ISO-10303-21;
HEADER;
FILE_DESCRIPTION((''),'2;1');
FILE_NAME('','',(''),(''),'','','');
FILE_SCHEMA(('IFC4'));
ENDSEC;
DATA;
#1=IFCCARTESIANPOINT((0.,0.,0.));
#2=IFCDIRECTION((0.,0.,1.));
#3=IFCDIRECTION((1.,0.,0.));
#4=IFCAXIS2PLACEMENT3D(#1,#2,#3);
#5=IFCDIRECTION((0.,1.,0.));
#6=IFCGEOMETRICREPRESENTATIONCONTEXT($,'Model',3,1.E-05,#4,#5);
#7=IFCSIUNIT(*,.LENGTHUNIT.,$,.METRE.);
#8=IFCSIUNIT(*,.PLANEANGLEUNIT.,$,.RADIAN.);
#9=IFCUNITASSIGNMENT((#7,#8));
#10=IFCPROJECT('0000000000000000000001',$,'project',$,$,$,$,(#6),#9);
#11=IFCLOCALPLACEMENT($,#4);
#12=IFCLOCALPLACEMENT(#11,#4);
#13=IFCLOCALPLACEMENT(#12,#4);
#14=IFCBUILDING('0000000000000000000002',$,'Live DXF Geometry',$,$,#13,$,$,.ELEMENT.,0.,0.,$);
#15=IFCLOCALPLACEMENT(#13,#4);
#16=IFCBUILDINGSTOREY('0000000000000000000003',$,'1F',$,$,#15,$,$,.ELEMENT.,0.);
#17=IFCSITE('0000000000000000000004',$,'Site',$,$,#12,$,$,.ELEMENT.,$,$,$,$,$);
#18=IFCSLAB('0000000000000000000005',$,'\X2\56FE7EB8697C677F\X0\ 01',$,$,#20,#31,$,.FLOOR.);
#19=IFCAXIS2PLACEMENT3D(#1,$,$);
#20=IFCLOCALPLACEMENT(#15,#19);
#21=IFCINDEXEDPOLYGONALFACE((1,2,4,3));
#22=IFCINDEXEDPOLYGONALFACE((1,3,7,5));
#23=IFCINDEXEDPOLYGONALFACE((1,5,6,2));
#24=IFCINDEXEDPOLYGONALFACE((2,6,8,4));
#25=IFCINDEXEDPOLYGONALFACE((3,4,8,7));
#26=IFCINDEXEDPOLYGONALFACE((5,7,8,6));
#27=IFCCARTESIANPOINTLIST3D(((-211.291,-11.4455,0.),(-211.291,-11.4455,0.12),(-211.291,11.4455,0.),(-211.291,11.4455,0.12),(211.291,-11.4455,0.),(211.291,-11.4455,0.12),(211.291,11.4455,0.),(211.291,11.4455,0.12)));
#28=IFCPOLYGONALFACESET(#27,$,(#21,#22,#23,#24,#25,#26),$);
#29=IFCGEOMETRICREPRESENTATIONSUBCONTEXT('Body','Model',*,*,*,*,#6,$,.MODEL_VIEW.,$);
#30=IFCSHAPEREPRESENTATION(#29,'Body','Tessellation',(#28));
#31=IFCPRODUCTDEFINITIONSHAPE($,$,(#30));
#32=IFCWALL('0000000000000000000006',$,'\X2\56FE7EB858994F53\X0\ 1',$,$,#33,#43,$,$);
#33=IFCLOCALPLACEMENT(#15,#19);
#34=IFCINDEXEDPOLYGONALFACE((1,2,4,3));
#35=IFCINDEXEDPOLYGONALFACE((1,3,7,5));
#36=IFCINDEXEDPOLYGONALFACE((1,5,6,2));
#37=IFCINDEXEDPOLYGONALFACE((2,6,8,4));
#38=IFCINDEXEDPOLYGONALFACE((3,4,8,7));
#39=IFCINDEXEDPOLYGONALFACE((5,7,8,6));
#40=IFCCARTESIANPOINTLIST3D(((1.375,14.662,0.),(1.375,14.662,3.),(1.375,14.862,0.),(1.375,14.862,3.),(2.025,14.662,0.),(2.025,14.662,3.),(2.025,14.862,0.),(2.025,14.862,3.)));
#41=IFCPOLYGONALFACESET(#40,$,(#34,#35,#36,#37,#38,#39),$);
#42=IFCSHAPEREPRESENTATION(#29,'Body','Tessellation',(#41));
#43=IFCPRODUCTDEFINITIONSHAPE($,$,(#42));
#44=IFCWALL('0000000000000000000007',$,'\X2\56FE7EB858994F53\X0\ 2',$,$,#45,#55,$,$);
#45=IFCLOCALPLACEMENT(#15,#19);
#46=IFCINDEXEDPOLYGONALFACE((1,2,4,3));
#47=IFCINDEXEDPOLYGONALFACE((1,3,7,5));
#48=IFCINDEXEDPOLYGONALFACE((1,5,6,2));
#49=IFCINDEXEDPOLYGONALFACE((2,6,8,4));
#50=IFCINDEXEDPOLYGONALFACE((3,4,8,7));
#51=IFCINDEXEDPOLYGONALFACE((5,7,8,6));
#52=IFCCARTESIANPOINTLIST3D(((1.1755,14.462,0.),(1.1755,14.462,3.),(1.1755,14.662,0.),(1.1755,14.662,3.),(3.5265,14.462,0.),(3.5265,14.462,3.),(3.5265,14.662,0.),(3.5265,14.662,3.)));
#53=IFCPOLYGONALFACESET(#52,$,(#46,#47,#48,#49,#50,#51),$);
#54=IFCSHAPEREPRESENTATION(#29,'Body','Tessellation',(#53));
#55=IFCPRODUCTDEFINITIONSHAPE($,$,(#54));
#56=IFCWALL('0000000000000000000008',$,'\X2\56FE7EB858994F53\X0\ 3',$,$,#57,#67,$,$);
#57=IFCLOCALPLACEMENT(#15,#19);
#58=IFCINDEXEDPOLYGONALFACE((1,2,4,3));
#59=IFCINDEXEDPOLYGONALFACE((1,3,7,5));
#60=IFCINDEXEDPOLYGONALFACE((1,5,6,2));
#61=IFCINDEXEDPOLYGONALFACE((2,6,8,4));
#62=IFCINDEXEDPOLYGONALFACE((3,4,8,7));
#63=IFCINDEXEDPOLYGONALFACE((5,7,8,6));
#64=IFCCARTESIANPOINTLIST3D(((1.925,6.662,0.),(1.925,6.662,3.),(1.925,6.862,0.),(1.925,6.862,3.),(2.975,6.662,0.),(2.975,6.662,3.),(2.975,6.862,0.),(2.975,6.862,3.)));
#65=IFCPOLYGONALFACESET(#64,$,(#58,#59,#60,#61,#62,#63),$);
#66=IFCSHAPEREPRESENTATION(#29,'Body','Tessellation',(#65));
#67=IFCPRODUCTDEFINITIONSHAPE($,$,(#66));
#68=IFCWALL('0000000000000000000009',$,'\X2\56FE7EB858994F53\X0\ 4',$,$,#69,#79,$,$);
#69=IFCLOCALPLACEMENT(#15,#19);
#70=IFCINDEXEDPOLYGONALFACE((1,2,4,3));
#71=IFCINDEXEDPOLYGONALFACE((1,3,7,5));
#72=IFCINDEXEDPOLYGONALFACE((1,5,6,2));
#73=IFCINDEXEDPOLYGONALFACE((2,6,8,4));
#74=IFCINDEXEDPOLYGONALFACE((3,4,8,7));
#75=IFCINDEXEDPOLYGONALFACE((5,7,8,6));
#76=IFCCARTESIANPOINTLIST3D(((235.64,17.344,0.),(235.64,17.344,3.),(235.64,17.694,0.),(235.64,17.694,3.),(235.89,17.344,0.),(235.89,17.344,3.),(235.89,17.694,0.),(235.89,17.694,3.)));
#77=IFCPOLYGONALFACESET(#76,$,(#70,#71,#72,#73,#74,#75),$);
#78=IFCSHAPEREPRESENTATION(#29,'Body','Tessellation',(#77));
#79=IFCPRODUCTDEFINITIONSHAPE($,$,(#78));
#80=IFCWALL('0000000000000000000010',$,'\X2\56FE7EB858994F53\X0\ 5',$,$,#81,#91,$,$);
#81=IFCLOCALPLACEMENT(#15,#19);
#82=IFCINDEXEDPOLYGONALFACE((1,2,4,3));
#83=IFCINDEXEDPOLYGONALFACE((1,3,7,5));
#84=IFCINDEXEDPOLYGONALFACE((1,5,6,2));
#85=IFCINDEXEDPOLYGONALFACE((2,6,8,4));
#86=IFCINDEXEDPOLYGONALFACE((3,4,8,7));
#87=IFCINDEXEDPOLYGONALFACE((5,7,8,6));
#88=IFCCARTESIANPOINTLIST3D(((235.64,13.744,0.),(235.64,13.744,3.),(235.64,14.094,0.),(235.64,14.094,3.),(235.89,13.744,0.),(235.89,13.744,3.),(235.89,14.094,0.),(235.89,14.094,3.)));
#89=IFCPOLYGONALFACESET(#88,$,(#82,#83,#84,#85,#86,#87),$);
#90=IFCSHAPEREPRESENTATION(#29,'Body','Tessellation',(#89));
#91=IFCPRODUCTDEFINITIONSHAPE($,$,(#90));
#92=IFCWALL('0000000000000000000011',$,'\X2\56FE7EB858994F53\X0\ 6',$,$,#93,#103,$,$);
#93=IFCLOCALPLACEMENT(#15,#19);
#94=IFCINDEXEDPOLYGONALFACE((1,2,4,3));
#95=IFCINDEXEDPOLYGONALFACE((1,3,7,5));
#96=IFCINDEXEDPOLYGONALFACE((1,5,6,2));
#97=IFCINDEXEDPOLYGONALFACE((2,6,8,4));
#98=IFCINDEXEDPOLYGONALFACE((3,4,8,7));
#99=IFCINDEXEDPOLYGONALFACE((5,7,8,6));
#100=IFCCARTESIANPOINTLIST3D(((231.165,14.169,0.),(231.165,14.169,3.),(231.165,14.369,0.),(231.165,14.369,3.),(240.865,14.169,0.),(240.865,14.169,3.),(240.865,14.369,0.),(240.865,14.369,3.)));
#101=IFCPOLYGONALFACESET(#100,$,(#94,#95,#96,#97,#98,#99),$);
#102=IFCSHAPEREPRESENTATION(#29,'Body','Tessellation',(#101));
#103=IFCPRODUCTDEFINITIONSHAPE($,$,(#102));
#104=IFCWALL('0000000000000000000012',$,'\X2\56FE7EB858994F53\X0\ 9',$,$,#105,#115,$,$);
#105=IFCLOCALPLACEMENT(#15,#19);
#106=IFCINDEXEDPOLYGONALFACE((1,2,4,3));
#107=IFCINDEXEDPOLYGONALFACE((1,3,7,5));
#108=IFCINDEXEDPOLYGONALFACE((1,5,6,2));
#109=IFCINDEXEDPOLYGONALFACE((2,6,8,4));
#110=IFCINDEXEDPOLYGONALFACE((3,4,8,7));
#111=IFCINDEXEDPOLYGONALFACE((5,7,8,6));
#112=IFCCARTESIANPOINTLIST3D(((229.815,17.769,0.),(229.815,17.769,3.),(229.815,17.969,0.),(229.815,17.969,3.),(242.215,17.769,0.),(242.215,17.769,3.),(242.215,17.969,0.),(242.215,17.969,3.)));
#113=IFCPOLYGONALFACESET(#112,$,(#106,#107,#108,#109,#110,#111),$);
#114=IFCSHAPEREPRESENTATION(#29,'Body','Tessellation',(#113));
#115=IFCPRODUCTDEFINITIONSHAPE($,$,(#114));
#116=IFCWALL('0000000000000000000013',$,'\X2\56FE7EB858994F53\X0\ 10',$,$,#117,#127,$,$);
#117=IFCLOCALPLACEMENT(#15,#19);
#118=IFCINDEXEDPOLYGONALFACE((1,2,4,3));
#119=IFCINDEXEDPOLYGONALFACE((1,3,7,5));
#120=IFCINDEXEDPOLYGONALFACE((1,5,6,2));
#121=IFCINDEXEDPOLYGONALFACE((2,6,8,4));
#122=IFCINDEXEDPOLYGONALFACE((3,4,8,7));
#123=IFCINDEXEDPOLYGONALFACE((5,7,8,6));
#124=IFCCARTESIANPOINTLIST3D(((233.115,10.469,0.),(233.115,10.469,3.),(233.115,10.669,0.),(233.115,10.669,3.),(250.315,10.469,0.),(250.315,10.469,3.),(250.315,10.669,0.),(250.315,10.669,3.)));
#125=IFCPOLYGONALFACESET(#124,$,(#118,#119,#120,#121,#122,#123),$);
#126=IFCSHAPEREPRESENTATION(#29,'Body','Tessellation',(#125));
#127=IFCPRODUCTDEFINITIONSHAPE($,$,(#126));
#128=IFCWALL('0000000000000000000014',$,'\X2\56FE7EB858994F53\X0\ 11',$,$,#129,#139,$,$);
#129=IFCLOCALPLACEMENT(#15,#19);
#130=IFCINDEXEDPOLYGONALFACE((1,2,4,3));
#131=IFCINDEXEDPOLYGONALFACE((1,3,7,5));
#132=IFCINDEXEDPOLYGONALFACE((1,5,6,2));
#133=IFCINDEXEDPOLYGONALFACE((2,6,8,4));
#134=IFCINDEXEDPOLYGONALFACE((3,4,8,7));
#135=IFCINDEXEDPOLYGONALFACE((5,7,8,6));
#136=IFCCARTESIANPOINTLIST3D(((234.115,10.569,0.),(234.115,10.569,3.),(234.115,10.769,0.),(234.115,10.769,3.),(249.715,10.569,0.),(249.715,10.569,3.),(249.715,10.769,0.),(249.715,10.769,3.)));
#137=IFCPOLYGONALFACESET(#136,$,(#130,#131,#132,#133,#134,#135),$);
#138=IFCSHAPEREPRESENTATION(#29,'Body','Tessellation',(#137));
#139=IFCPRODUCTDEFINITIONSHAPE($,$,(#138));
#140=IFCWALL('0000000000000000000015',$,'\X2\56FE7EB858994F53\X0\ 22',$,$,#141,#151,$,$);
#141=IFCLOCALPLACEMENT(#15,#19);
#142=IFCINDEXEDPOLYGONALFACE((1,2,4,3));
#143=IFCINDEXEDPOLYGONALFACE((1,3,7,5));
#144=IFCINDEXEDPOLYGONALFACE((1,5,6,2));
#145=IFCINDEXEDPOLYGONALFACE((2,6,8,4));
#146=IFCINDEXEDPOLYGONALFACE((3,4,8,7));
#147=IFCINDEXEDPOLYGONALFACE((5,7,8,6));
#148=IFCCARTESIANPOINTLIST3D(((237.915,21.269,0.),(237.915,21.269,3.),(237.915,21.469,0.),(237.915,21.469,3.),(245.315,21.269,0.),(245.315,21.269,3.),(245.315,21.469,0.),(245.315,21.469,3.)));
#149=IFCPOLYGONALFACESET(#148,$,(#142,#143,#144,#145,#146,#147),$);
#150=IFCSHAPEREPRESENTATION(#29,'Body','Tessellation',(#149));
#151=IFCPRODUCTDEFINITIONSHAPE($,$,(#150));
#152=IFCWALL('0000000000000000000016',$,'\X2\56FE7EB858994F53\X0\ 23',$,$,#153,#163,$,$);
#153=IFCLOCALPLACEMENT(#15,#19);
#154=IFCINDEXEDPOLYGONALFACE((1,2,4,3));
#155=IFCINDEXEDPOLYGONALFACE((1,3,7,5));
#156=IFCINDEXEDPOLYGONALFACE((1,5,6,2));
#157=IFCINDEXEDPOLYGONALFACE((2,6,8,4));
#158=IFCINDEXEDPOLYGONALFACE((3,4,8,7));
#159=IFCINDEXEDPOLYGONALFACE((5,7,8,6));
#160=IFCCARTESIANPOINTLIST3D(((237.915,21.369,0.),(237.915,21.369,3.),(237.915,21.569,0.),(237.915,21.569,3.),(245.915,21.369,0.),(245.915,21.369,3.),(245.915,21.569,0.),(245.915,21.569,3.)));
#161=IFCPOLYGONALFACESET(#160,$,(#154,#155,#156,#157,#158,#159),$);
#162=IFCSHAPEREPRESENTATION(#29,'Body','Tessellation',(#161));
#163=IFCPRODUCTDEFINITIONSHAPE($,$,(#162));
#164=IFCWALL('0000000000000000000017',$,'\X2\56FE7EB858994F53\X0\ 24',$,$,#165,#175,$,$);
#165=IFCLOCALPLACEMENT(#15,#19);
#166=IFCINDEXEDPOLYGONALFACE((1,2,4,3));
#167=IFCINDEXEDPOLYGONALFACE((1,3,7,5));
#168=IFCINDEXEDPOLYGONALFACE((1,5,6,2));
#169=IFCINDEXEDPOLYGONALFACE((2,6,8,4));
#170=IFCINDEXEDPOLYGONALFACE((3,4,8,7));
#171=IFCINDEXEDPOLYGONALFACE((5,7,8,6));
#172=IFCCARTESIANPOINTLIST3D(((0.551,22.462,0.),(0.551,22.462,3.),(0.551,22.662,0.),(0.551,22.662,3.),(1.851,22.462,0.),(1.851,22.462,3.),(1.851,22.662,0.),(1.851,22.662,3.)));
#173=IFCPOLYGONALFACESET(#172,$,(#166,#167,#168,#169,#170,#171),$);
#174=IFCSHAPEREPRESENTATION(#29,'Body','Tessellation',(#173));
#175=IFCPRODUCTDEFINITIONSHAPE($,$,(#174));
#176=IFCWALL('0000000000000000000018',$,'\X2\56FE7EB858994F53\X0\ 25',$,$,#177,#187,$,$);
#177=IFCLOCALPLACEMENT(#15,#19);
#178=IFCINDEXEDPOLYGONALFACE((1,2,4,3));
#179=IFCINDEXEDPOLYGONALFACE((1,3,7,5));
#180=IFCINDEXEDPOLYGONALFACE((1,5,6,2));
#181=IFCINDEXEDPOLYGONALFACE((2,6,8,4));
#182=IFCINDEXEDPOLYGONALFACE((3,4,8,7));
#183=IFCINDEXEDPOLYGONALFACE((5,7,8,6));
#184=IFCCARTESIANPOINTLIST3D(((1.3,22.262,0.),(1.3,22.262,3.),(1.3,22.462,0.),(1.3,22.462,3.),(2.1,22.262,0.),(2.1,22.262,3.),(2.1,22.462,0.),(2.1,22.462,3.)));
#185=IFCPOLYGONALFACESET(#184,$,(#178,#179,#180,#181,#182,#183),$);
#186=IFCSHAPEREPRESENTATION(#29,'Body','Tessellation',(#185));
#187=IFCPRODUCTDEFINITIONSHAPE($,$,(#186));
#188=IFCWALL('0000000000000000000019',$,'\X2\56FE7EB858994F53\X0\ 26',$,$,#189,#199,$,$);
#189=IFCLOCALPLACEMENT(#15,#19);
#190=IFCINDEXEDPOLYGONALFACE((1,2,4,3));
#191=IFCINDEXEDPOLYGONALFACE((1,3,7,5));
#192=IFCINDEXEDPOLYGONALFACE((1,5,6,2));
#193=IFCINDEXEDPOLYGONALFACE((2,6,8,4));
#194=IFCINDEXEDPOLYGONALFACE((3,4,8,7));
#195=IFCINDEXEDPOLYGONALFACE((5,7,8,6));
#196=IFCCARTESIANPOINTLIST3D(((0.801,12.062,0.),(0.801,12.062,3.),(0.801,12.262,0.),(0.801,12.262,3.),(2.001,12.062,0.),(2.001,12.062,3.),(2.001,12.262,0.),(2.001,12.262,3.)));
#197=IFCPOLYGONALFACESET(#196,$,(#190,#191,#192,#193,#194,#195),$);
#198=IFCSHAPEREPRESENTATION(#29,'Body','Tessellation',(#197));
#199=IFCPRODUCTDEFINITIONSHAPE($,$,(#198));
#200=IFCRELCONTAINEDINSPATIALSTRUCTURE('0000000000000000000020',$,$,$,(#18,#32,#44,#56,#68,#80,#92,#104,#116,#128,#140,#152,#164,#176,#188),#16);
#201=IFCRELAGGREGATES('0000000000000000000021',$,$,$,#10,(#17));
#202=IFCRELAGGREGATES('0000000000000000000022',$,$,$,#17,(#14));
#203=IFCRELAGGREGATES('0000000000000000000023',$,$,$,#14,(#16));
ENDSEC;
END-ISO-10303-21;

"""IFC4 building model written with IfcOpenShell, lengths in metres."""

from ifc_helpers import new_model, si_unit, direction, frame, frame_2d, origin_with_axes, place, context, subcontext, project, spatial, rectangle, extrude, element, save


model = new_model("IFC4")

# Units and contexts
model_context = context("Model", 3, precision=1e-05, world=origin_with_axes(), true_north=direction((0.0, 1.0, 0.0)))
body_context = subcontext(model_context, "Body", "Model", "MODEL_VIEW")
ifc_project = project(units=[si_unit("LENGTHUNIT", "METRE"), si_unit("PLANEANGLEUNIT", "RADIAN")], contexts=[model_context])

# Site, building, storey
placement = place(None, origin_with_axes())
site_placement = place(placement, origin_with_axes())
site = spatial("IfcSite", under=ifc_project, at=site_placement, Name="Site", CompositionType="ELEMENT")
building_placement = place(site_placement, origin_with_axes())
building = spatial("IfcBuilding", under=site, at=building_placement, Name="Live DXF Geometry", CompositionType="ELEMENT", ElevationOfRefHeight=0.0, ElevationOfTerrain=0.0)
storey_placement = place(building_placement, origin_with_axes())
storey = spatial("IfcBuildingStorey", under=building, at=storey_placement, Name="1F", CompositionType="ELEMENT", Elevation=0.0)

# Slab
slab_placement = place(storey_placement, origin_with_axes())
element("IfcSlab", 1, at=slab_placement, inside=storey, Name="图纸楼板 01", PredefinedType="FLOOR", context=body_context, shape_type="SweptSolid", body=[
    extrude(rectangle(XDim=422.582, YDim=22.891, at=frame_2d((0.0, 0.0), x_axis=(1.0, 0.0, 0.0))), frame((0.0, 0.0, 0.0), z_axis=(0.0, 0.0, 1.0)), (0.0, 0.0, 1.0), 0.12),
])

# Walls
wall_1_placement = place(storey_placement, frame((1.7, 14.762, 0.0), z_axis=(0.0, 0.0, 1.0), x_axis=(1.0, 0.0, 0.0)))
element("IfcWall", 2, at=wall_1_placement, inside=storey, Name="图纸墙体 1", context=body_context, shape_type="SweptSolid", body=[
    extrude(rectangle(XDim=0.65, YDim=0.2, at=frame_2d((0.0, 0.0), x_axis=(1.0, 0.0, 0.0))), frame((0.0, 0.0, 0.0), z_axis=(0.0, 0.0, 1.0)), (0.0, 0.0, 1.0), 3.0),
])
wall_2_placement = place(storey_placement, frame((2.351, 14.562, 0.0), z_axis=(0.0, 0.0, 1.0), x_axis=(-1.0, 0.0, 0.0)))
element("IfcWall", 3, at=wall_2_placement, inside=storey, Name="图纸墙体 2", context=body_context, shape_type="SweptSolid", body=[
    extrude(rectangle(XDim=2.351, YDim=0.2, at=frame_2d((0.0, 0.0), x_axis=(1.0, 0.0, 0.0))), frame((0.0, 0.0, 0.0), z_axis=(0.0, 0.0, 1.0)), (0.0, 0.0, 1.0), 3.0),
])
wall_3_placement = place(storey_placement, frame((2.45, 6.762, 0.0), z_axis=(0.0, 0.0, 1.0), x_axis=(-1.0, 0.0, 0.0)))
element("IfcWall", 4, at=wall_3_placement, inside=storey, Name="图纸墙体 3", context=body_context, shape_type="SweptSolid", body=[
    extrude(rectangle(XDim=1.05, YDim=0.2, at=frame_2d((0.0, 0.0), x_axis=(1.0, 0.0, 0.0))), frame((0.0, 0.0, 0.0), z_axis=(0.0, 0.0, 1.0)), (0.0, 0.0, 1.0), 3.0),
])
for number, where, z_axis, x_axis, name in (
    (5, (235.765, 17.519, 0.0), (0.0, 0.0, 1.0), (1.0, 0.0, 0.0), "图纸墙体 4"),
    (6, (235.765, 13.919, 0.0), (0.0, 0.0, 1.0), (1.0, 0.0, 0.0), "图纸墙体 5"),
):
    element("IfcWall", number, at=place(storey_placement, frame(where, z_axis=z_axis, x_axis=x_axis)), inside=storey, Name=name, context=body_context, shape_type="SweptSolid", body=[
        extrude(rectangle(XDim=0.25, YDim=0.35, at=frame_2d((0.0, 0.0), x_axis=(1.0, 0.0, 0.0))), frame((0.0, 0.0, 0.0), z_axis=(0.0, 0.0, 1.0)), (0.0, 0.0, 1.0), 3.0),
    ])
wall_4_placement = place(storey_placement, frame((236.015, 14.269, 0.0), z_axis=(0.0, 0.0, 1.0), x_axis=(-1.0, 0.0, 0.0)))
element("IfcWall", 7, at=wall_4_placement, inside=storey, Name="图纸墙体 6", context=body_context, shape_type="SweptSolid", body=[
    extrude(rectangle(XDim=9.7, YDim=0.2, at=frame_2d((0.0, 0.0), x_axis=(1.0, 0.0, 0.0))), frame((0.0, 0.0, 0.0), z_axis=(0.0, 0.0, 1.0)), (0.0, 0.0, 1.0), 3.0),
])
wall_5_placement = place(storey_placement, frame((236.015, 17.869, 0.0), z_axis=(0.0, 0.0, 1.0), x_axis=(-1.0, 0.0, 0.0)))
element("IfcWall", 8, at=wall_5_placement, inside=storey, Name="图纸墙体 9", context=body_context, shape_type="SweptSolid", body=[
    extrude(rectangle(XDim=12.4, YDim=0.2, at=frame_2d((0.0, 0.0), x_axis=(1.0, 0.0, 0.0))), frame((0.0, 0.0, 0.0), z_axis=(0.0, 0.0, 1.0)), (0.0, 0.0, 1.0), 3.0),
])
wall_6_placement = place(storey_placement, frame((241.715, 10.569, 0.0), z_axis=(0.0, 0.0, 1.0), x_axis=(-1.0, 0.0, 0.0)))
element("IfcWall", 9, at=wall_6_placement, inside=storey, Name="图纸墙体 10", context=body_context, shape_type="SweptSolid", body=[
    extrude(rectangle(XDim=17.2, YDim=0.2, at=frame_2d((0.0, 0.0), x_axis=(1.0, 0.0, 0.0))), frame((0.0, 0.0, 0.0), z_axis=(0.0, 0.0, 1.0)), (0.0, 0.0, 1.0), 3.0),
])
wall_7_placement = place(storey_placement, frame((241.915, 10.669, 0.0), z_axis=(0.0, 0.0, 1.0), x_axis=(-1.0, 0.0, 0.0)))
element("IfcWall", 10, at=wall_7_placement, inside=storey, Name="图纸墙体 11", context=body_context, shape_type="SweptSolid", body=[
    extrude(rectangle(XDim=15.6, YDim=0.2, at=frame_2d((0.0, 0.0), x_axis=(1.0, 0.0, 0.0))), frame((0.0, 0.0, 0.0), z_axis=(0.0, 0.0, 1.0)), (0.0, 0.0, 1.0), 3.0),
])
wall_8_placement = place(storey_placement, frame((241.615, 21.369, 0.0), z_axis=(0.0, 0.0, 1.0), x_axis=(-1.0, 0.0, 0.0)))
element("IfcWall", 11, at=wall_8_placement, inside=storey, Name="图纸墙体 22", context=body_context, shape_type="SweptSolid", body=[
    extrude(rectangle(XDim=7.4, YDim=0.2, at=frame_2d((0.0, 0.0), x_axis=(1.0, 0.0, 0.0))), frame((0.0, 0.0, 0.0), z_axis=(0.0, 0.0, 1.0)), (0.0, 0.0, 1.0), 3.0),
])
wall_9_placement = place(storey_placement, frame((241.915, 21.469, 0.0), z_axis=(0.0, 0.0, 1.0), x_axis=(-1.0, 0.0, 0.0)))
element("IfcWall", 12, at=wall_9_placement, inside=storey, Name="图纸墙体 23", context=body_context, shape_type="SweptSolid", body=[
    extrude(rectangle(XDim=8.0, YDim=0.2, at=frame_2d((0.0, 0.0), x_axis=(1.0, 0.0, 0.0))), frame((0.0, 0.0, 0.0), z_axis=(0.0, 0.0, 1.0)), (0.0, 0.0, 1.0), 3.0),
])
wall_10_placement = place(storey_placement, frame((1.201, 22.562, 0.0), z_axis=(0.0, 0.0, 1.0), x_axis=(1.0, 0.0, 0.0)))
element("IfcWall", 13, at=wall_10_placement, inside=storey, Name="图纸墙体 24", context=body_context, shape_type="SweptSolid", body=[
    extrude(rectangle(XDim=1.3, YDim=0.2, at=frame_2d((0.0, 0.0), x_axis=(1.0, 0.0, 0.0))), frame((0.0, 0.0, 0.0), z_axis=(0.0, 0.0, 1.0)), (0.0, 0.0, 1.0), 3.0),
])
wall_11_placement = place(storey_placement, frame((1.7, 22.362, 0.0), z_axis=(0.0, 0.0, 1.0), x_axis=(1.0, 0.0, 0.0)))
element("IfcWall", 14, at=wall_11_placement, inside=storey, Name="图纸墙体 25", context=body_context, shape_type="SweptSolid", body=[
    extrude(rectangle(XDim=0.8, YDim=0.2, at=frame_2d((0.0, 0.0), x_axis=(1.0, 0.0, 0.0))), frame((0.0, 0.0, 0.0), z_axis=(0.0, 0.0, 1.0)), (0.0, 0.0, 1.0), 3.0),
])
wall_12_placement = place(storey_placement, frame((1.401, 12.162, 0.0), z_axis=(0.0, 0.0, 1.0), x_axis=(1.0, 0.0, 0.0)))
element("IfcWall", 15, at=wall_12_placement, inside=storey, Name="图纸墙体 26", context=body_context, shape_type="SweptSolid", body=[
    extrude(rectangle(XDim=1.2, YDim=0.2, at=frame_2d((0.0, 0.0), x_axis=(1.0, 0.0, 0.0))), frame((0.0, 0.0, 0.0), z_axis=(0.0, 0.0, 1.0)), (0.0, 0.0, 1.0), 3.0),
])

save(model, "model.ifc")
